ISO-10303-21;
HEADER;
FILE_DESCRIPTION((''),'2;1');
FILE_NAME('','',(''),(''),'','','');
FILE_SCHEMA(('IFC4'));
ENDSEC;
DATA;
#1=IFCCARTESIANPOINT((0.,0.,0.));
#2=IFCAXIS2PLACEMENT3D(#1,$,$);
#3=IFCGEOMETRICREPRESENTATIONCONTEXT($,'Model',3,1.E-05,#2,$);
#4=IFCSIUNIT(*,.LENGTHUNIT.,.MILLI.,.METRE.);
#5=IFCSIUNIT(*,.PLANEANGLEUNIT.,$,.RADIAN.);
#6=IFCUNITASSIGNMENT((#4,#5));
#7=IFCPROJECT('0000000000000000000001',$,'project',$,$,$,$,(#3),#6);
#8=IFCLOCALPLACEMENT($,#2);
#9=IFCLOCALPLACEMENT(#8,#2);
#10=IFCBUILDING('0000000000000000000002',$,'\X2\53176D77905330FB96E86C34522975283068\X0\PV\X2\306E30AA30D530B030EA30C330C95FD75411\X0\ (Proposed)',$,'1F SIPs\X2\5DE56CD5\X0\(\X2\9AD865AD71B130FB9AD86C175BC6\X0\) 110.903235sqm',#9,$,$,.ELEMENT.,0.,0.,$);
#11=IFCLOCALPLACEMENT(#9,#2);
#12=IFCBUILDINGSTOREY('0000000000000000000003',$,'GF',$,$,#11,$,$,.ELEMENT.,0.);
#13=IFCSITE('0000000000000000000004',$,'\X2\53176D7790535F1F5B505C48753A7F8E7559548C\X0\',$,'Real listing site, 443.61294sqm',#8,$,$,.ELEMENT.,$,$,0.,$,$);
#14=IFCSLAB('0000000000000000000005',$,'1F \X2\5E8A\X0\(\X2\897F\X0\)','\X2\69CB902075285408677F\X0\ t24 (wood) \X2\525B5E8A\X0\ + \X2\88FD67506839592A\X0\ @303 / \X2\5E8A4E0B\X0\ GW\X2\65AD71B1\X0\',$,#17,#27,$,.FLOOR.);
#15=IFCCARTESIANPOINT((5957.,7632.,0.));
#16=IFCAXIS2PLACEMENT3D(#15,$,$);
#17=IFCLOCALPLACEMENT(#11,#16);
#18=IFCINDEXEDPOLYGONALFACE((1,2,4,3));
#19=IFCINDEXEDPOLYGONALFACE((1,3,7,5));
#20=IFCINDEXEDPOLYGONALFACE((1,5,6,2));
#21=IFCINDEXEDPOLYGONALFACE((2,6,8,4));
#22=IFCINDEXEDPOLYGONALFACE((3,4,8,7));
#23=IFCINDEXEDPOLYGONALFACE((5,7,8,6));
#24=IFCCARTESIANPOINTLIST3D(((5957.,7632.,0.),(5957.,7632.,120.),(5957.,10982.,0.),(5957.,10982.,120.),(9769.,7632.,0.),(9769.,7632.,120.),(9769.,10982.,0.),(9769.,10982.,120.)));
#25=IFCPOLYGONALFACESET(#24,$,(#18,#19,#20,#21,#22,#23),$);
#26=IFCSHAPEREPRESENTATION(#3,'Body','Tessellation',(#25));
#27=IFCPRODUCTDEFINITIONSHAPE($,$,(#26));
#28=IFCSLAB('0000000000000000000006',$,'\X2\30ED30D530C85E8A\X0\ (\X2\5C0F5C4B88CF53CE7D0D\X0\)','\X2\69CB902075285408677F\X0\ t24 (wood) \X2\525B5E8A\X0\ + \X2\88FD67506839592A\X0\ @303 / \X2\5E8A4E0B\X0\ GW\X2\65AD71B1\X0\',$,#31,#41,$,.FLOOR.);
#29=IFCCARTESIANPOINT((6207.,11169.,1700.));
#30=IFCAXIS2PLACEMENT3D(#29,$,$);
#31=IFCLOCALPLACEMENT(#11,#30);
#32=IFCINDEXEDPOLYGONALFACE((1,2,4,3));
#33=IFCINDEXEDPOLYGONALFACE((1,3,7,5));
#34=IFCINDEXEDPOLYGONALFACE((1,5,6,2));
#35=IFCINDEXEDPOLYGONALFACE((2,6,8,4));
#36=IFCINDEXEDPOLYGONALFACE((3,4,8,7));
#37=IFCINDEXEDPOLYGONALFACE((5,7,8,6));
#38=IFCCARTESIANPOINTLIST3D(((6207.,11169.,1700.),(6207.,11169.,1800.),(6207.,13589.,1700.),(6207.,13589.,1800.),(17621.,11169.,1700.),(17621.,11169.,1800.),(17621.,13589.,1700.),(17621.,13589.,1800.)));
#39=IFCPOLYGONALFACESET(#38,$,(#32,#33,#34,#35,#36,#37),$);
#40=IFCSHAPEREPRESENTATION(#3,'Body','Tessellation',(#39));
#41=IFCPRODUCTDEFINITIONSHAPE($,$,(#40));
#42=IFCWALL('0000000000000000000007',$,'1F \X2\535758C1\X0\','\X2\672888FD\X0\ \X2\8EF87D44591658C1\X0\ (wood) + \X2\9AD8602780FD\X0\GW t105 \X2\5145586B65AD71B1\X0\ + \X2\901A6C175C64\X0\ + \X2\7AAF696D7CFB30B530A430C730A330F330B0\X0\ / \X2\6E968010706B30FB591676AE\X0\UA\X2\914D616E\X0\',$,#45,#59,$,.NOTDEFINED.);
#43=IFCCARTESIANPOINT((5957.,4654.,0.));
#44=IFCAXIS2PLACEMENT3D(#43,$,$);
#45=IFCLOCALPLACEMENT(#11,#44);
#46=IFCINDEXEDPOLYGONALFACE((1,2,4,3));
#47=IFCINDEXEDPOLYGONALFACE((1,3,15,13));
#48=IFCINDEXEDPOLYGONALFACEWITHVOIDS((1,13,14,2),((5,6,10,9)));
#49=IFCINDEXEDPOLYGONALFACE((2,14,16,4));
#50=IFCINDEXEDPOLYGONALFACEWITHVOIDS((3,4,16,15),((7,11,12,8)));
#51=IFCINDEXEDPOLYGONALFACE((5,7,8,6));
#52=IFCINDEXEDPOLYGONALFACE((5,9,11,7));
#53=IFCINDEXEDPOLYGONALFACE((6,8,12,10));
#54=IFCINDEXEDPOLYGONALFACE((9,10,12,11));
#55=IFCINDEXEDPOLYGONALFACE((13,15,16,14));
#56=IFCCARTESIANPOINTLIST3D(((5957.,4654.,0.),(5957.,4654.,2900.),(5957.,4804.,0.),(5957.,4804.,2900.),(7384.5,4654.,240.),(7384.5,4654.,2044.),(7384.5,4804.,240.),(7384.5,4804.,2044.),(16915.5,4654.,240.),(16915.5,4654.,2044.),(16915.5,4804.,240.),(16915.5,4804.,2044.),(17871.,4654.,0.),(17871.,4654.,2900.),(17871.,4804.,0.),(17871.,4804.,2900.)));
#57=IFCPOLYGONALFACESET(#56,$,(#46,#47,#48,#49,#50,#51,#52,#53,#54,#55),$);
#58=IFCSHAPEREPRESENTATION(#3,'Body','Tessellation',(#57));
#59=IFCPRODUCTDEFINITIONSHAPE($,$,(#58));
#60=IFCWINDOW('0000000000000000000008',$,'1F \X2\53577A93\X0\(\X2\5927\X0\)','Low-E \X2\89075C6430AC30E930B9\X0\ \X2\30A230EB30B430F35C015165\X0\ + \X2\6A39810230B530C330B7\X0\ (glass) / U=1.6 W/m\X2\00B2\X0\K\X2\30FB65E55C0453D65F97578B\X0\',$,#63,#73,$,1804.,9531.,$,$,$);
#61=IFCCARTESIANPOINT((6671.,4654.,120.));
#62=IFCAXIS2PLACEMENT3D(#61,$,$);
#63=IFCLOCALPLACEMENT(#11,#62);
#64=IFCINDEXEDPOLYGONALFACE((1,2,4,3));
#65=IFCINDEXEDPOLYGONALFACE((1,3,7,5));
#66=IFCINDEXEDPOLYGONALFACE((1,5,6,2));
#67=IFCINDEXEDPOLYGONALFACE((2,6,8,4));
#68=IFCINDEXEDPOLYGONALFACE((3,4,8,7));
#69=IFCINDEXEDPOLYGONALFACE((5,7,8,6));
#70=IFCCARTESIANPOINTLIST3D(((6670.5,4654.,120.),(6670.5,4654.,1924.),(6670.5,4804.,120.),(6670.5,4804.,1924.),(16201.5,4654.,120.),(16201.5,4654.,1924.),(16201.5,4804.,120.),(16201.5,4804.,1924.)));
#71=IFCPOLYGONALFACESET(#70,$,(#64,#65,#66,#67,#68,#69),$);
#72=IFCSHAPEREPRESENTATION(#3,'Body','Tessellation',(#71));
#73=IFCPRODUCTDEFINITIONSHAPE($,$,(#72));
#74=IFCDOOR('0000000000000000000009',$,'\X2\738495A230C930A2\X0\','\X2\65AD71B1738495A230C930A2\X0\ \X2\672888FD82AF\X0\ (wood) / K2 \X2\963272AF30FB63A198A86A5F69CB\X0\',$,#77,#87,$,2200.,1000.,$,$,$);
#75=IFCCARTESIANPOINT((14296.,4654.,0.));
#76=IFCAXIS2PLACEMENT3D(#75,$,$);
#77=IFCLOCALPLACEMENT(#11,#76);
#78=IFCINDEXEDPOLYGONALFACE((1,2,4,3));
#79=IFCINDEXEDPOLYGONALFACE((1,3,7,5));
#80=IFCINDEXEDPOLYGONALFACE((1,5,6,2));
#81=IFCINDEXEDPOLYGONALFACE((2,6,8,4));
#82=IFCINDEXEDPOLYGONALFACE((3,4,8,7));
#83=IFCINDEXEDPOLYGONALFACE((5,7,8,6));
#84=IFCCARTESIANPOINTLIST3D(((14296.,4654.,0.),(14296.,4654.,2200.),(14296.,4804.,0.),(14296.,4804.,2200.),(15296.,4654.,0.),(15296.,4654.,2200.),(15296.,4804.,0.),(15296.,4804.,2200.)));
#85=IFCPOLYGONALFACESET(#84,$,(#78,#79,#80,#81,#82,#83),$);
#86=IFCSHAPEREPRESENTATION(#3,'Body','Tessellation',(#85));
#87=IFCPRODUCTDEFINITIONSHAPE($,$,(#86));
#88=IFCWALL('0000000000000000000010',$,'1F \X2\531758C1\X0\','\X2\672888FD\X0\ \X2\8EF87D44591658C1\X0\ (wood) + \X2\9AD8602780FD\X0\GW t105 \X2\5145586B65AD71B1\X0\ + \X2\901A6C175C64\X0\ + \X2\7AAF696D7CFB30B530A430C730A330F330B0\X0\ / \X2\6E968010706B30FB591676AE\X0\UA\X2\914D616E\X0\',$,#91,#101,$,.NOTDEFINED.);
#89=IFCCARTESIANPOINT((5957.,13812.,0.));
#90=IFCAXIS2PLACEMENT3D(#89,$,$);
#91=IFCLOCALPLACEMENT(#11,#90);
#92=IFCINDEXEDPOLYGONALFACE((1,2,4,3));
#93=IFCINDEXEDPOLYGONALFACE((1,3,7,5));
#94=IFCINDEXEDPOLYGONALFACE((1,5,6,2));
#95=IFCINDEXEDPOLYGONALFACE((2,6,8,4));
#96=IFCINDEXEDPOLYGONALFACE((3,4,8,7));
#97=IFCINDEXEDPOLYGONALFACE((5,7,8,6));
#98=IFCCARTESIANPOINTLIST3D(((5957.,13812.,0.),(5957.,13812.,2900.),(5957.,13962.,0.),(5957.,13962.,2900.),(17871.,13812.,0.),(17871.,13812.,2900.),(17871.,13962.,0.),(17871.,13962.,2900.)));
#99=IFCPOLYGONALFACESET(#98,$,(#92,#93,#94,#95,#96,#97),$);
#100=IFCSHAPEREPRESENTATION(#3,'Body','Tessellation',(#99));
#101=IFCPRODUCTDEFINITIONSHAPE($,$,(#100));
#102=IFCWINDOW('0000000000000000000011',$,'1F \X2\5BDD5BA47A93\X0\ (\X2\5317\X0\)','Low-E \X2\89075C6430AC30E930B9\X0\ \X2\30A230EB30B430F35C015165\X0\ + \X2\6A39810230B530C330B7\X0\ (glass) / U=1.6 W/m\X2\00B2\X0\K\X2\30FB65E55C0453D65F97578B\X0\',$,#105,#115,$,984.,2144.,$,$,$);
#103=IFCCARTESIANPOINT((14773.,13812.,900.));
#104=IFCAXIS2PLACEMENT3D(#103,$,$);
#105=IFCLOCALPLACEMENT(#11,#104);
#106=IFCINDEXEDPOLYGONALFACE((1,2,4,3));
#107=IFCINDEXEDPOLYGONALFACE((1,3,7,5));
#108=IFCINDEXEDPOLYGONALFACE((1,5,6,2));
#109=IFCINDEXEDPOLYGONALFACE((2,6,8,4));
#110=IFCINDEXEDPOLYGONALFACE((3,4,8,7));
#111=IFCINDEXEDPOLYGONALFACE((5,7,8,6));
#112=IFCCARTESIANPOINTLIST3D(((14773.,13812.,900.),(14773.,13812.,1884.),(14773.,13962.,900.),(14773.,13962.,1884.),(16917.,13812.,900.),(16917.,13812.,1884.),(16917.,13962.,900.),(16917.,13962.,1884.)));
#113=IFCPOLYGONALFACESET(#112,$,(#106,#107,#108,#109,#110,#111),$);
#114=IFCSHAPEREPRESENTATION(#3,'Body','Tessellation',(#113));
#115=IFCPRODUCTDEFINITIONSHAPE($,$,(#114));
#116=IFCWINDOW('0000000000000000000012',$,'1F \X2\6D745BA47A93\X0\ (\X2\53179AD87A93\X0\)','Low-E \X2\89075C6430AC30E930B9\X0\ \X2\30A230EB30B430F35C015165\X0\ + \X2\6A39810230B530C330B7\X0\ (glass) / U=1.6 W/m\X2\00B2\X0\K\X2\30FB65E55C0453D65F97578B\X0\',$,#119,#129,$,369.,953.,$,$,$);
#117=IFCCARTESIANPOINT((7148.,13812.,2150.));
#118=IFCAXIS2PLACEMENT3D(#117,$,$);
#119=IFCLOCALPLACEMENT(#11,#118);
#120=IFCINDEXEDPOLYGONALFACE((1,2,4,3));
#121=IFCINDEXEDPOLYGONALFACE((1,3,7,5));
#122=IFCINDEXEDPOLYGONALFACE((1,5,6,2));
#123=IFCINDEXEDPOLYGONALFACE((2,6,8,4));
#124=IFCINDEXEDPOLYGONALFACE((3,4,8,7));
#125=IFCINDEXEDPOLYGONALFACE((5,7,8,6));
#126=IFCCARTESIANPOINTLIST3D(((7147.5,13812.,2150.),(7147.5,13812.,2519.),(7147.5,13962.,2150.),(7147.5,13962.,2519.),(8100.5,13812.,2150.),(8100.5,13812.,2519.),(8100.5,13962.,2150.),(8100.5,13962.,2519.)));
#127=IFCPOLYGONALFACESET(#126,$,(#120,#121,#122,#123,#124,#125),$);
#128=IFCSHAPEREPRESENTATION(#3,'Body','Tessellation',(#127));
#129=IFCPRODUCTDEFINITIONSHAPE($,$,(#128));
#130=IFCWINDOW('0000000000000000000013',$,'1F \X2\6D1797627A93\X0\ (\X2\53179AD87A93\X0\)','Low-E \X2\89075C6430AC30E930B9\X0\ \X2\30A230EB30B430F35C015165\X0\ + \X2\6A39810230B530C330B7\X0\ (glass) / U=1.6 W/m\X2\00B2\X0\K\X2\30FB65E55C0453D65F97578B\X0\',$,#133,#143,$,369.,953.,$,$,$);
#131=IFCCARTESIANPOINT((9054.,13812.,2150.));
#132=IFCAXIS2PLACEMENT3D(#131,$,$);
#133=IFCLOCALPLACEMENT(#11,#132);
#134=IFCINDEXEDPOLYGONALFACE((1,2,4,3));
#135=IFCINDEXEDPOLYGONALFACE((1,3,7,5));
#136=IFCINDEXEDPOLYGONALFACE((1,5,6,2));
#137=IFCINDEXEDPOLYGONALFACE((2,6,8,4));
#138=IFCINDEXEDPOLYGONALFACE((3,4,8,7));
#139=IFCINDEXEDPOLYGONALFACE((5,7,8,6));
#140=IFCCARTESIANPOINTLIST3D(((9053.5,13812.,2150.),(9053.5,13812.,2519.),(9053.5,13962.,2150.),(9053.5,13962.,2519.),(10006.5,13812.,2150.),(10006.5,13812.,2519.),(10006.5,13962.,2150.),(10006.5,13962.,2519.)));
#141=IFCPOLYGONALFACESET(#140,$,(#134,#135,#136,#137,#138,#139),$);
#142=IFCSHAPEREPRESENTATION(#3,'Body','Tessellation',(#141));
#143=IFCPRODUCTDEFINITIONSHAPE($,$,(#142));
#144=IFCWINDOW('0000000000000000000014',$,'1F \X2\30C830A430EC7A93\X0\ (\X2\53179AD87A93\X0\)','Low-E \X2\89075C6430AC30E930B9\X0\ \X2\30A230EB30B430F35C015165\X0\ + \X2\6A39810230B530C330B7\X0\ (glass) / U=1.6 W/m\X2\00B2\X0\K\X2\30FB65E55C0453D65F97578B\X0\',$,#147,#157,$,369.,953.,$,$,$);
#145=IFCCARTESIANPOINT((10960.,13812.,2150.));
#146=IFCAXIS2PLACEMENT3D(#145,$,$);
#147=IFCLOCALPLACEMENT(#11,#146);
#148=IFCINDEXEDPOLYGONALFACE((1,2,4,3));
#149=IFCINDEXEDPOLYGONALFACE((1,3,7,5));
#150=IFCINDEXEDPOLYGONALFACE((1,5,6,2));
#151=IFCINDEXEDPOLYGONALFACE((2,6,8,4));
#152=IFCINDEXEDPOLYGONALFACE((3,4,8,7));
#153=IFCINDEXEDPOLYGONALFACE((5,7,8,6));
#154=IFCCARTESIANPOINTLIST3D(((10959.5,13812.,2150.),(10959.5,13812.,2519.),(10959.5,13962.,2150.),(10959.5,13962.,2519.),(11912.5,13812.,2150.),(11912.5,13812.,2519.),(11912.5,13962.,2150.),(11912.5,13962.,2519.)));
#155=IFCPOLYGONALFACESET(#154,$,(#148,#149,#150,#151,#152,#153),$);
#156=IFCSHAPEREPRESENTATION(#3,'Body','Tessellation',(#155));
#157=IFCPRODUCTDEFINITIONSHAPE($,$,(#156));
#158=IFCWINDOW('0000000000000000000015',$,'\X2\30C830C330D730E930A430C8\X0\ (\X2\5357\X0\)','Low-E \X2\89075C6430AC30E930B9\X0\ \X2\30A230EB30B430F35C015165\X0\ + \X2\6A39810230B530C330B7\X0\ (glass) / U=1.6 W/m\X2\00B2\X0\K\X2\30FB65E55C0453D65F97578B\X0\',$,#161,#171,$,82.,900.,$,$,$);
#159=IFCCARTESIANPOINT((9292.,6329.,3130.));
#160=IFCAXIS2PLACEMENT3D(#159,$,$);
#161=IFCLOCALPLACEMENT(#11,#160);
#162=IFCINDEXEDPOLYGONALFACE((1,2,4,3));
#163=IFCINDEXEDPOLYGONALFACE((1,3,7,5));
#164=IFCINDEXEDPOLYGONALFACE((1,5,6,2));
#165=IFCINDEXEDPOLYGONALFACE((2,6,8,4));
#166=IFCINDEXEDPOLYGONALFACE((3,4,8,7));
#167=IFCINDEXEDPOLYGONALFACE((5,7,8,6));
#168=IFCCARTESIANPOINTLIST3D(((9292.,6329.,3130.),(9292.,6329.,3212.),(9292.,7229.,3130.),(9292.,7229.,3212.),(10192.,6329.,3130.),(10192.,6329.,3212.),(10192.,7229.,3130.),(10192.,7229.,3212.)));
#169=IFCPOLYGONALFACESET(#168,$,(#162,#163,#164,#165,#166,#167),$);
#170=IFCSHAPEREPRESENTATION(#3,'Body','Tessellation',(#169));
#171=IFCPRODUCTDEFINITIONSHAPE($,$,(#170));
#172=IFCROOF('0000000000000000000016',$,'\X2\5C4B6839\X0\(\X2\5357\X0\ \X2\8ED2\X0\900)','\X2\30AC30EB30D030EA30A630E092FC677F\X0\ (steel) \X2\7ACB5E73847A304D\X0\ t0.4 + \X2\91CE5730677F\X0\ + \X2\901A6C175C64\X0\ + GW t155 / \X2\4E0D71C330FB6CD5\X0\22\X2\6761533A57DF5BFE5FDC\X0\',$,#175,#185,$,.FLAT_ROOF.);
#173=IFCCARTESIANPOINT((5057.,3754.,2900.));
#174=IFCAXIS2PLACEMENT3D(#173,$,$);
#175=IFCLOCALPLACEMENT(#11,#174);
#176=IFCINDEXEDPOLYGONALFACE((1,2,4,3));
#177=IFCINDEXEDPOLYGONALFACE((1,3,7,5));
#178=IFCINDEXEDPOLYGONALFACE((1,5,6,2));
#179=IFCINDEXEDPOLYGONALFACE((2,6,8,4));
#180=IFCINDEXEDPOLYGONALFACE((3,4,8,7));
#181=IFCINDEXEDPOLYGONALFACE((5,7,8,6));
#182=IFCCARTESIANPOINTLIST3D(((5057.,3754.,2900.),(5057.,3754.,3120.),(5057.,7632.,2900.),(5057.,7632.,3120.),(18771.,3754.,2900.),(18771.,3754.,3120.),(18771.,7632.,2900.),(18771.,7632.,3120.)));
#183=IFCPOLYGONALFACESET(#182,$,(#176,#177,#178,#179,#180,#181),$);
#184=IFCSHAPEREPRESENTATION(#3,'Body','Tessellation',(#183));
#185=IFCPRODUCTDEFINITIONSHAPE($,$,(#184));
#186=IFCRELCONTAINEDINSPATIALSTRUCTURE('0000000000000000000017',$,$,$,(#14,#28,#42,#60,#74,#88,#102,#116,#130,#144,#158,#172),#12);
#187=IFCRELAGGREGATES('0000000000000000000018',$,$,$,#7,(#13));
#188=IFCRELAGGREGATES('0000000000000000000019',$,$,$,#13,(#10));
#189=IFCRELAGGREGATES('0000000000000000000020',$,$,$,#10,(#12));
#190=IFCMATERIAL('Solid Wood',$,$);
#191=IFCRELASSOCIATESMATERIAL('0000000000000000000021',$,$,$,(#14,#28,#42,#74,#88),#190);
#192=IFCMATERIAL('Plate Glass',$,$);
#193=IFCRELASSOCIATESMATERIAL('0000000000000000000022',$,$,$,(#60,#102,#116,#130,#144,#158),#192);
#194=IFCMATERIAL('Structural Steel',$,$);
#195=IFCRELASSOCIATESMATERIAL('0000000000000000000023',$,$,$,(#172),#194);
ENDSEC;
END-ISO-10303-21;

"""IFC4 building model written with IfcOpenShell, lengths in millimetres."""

from ifc_helpers import new_model, si_unit, frame, frame_2d, origin, place, context, project, spatial, rectangle, extrude, material, element, fill, save


model = new_model("IFC4")

# Units and contexts
model_context = context("Model", 3, precision=1e-05, world=origin())
ifc_project = project(units=[si_unit("LENGTHUNIT", "METRE", prefix="MILLI"), si_unit("PLANEANGLEUNIT", "RADIAN")], contexts=[model_context])

# Site, building, storey
site_placement = place(None, origin())
site = spatial("IfcSite", under=ifc_project, at=site_placement, Name="北海道弟子屈町美留和", ObjectType="Real listing site, 443.61294sqm", CompositionType="ELEMENT", RefElevation=0.0)
building_placement = place(site_placement, origin())
building = spatial("IfcBuilding", under=site, at=building_placement, Name="北海道・雨水利用とPVのオフグリッド志向 (Proposed)", ObjectType="1F SIPs工法(高断熱・高気密) 110.903235sqm", CompositionType="ELEMENT", ElevationOfRefHeight=0.0, ElevationOfTerrain=0.0)
storey_placement = place(building_placement, origin())
storey = spatial("IfcBuildingStorey", under=building, at=storey_placement, Name="GF", CompositionType="ELEMENT", Elevation=0.0)

# Slabs
ifc_material_1 = material(Name="Solid Wood")
slab_1_placement = place(storey_placement, frame((5957.0, 7632.0, 0.0)))
element("IfcSlab", 1, at=slab_1_placement, inside=storey, material=ifc_material_1, Name="1F 床(西)", Description="構造用合板 t24 (wood) 剛床 + 製材根太 @303 / 床下 GW断熱", PredefinedType="FLOOR", context=model_context, shape_type="SweptSolid", body=[
    extrude(rectangle(XDim=3812.0, YDim=3350.0, at=frame_2d((1906.0, 1675.0))), frame((5957.0, 7632.0, 0.0)), (0.0, 0.0, 1.0), 120.0),
])
slab_2_placement = place(storey_placement, frame((6207.0, 11169.0, 1700.0)))
element("IfcSlab", 2, at=slab_2_placement, inside=storey, material=ifc_material_1, Name="ロフト床 (小屋裏収納)", Description="構造用合板 t24 (wood) 剛床 + 製材根太 @303 / 床下 GW断熱", PredefinedType="FLOOR", context=model_context, shape_type="SweptSolid", body=[
    extrude(rectangle(XDim=11414.0, YDim=2420.0, at=frame_2d((5707.0, 1210.0))), frame((6207.0, 11169.0, 1700.0)), (0.0, 0.0, 1.0), 100.0),
])

# Wall, openings, window, door
wall_1_placement = place(storey_placement, frame((5957.0, 4654.0, 0.0)))
wall_1 = element("IfcWall", 3, at=wall_1_placement, inside=storey, material=ifc_material_1, Name="1F 南壁", Description="木製 軸組外壁 (wood) + 高性能GW t105 充填断熱 + 通気層 + 窯業系サイディング / 準耐火・外皮UA配慮", PredefinedType="NOTDEFINED", context=model_context, shape_type="SweptSolid", body=[
    extrude(rectangle(XDim=11914.0, YDim=150.0, at=frame_2d((5957.0, 75.0))), frame((5957.0, 4654.0, 0.0)), (0.0, 0.0, 1.0), 2900.0),
])
opening_1_placement = place(storey_placement, frame((6671.0, 4654.0, 120.0)))
opening_1 = element("IfcOpeningElement", 4, at=opening_1_placement, cuts=wall_1, PredefinedType="NOTDEFINED", context=model_context, shape_type="SweptSolid", body=[
    extrude(rectangle(XDim=9531.0, YDim=150.0, at=frame_2d((4765.0, 75.0))), frame((6671.0, 4654.0, 120.0)), (0.0, 0.0, 1.0), 1804.0),
])
opening_2_placement = place(storey_placement, frame((14296.0, 4654.0, 0.0)))
opening_2 = element("IfcOpeningElement", 5, at=opening_2_placement, cuts=wall_1, PredefinedType="NOTDEFINED", context=model_context, shape_type="SweptSolid", body=[
    extrude(rectangle(XDim=1000.0, YDim=150.0, at=frame_2d((500.0, 75.0))), frame((14296.0, 4654.0, 0.0)), (0.0, 0.0, 1.0), 2200.0),
])
ifc_material_2 = material(Name="Plate Glass")
window_1_placement = place(storey_placement, frame((6671.0, 4654.0, 120.0)))
window_1 = element("IfcWindow", 6, at=window_1_placement, inside=storey, material=ifc_material_2, Name="1F 南窓(大)", Description="Low-E 複層ガラス アルゴン封入 + 樹脂サッシ (glass) / U=1.6 W/m²K・日射取得型", OverallHeight=1804.0, OverallWidth=9531.0, context=model_context, shape_type="SweptSolid", body=[
    extrude(rectangle(XDim=9531.0, YDim=150.0, at=frame_2d((4765.0, 75.0))), frame((6671.0, 4654.0, 120.0)), (0.0, 0.0, 1.0), 1804.0),
])
fill(opening_1, window_1)
door_1_placement = place(storey_placement, frame((14296.0, 4654.0, 0.0)))
door_1 = element("IfcDoor", 7, at=door_1_placement, inside=storey, material=ifc_material_1, Name="玄関ドア", Description="断熱玄関ドア 木製芯 (wood) / K2 防犯・採風機構", OverallHeight=2200.0, OverallWidth=1000.0, context=model_context, shape_type="SweptSolid", body=[
    extrude(rectangle(XDim=1000.0, YDim=150.0, at=frame_2d((500.0, 75.0))), frame((14296.0, 4654.0, 0.0)), (0.0, 0.0, 1.0), 2200.0),
])
fill(opening_2, door_1)

# Wall, openings, windows
wall_2_placement = place(storey_placement, frame((5957.0, 13812.0, 0.0)))
wall_2 = element("IfcWall", 8, at=wall_2_placement, inside=storey, material=ifc_material_1, Name="1F 北壁", Description="木製 軸組外壁 (wood) + 高性能GW t105 充填断熱 + 通気層 + 窯業系サイディング / 準耐火・外皮UA配慮", PredefinedType="NOTDEFINED", context=model_context, shape_type="SweptSolid", body=[
    extrude(rectangle(XDim=11914.0, YDim=150.0, at=frame_2d((5957.0, 75.0))), frame((5957.0, 13812.0, 0.0)), (0.0, 0.0, 1.0), 2900.0),
])
opening_3_placement = place(storey_placement, frame((14773.0, 13812.0, 900.0)))
opening_3 = element("IfcOpeningElement", 9, at=opening_3_placement, cuts=wall_2, PredefinedType="NOTDEFINED", context=model_context, shape_type="SweptSolid", body=[
    extrude(rectangle(XDim=2144.0, YDim=150.0, at=frame_2d((1072.0, 75.0))), frame((14773.0, 13812.0, 900.0)), (0.0, 0.0, 1.0), 984.0),
])
opening_4_placement = place(storey_placement, frame((7148.0, 13812.0, 2150.0)))
opening_4 = element("IfcOpeningElement", 10, at=opening_4_placement, cuts=wall_2, PredefinedType="NOTDEFINED", context=model_context, shape_type="SweptSolid", body=[
    extrude(rectangle(XDim=953.0, YDim=150.0, at=frame_2d((476.0, 75.0))), frame((7148.0, 13812.0, 2150.0)), (0.0, 0.0, 1.0), 369.0),
])
opening_5_placement = place(storey_placement, frame((9054.0, 13812.0, 2150.0)))
opening_5 = element("IfcOpeningElement", 11, at=opening_5_placement, cuts=wall_2, PredefinedType="NOTDEFINED", context=model_context, shape_type="SweptSolid", body=[
    extrude(rectangle(XDim=953.0, YDim=150.0, at=frame_2d((476.0, 75.0))), frame((9054.0, 13812.0, 2150.0)), (0.0, 0.0, 1.0), 369.0),
])
opening_6_placement = place(storey_placement, frame((10960.0, 13812.0, 2150.0)))
opening_6 = element("IfcOpeningElement", 12, at=opening_6_placement, cuts=wall_2, PredefinedType="NOTDEFINED", context=model_context, shape_type="SweptSolid", body=[
    extrude(rectangle(XDim=953.0, YDim=150.0, at=frame_2d((476.0, 75.0))), frame((10960.0, 13812.0, 2150.0)), (0.0, 0.0, 1.0), 369.0),
])
window_2_placement = place(storey_placement, frame((14773.0, 13812.0, 900.0)))
window_2 = element("IfcWindow", 13, at=window_2_placement, inside=storey, material=ifc_material_2, Name="1F 寝室窓 (北)", Description="Low-E 複層ガラス アルゴン封入 + 樹脂サッシ (glass) / U=1.6 W/m²K・日射取得型", OverallHeight=984.0, OverallWidth=2144.0, context=model_context, shape_type="SweptSolid", body=[
    extrude(rectangle(XDim=2144.0, YDim=150.0, at=frame_2d((1072.0, 75.0))), frame((14773.0, 13812.0, 900.0)), (0.0, 0.0, 1.0), 984.0),
])
fill(opening_3, window_2)
window_3_placement = place(storey_placement, frame((7148.0, 13812.0, 2150.0)))
window_3 = element("IfcWindow", 14, at=window_3_placement, inside=storey, material=ifc_material_2, Name="1F 浴室窓 (北高窓)", Description="Low-E 複層ガラス アルゴン封入 + 樹脂サッシ (glass) / U=1.6 W/m²K・日射取得型", OverallHeight=369.0, OverallWidth=953.0, context=model_context, shape_type="SweptSolid", body=[
    extrude(rectangle(XDim=953.0, YDim=150.0, at=frame_2d((476.0, 75.0))), frame((7148.0, 13812.0, 2150.0)), (0.0, 0.0, 1.0), 369.0),
])
fill(opening_4, window_3)
window_4_placement = place(storey_placement, frame((9054.0, 13812.0, 2150.0)))
window_4 = element("IfcWindow", 15, at=window_4_placement, inside=storey, material=ifc_material_2, Name="1F 洗面窓 (北高窓)", Description="Low-E 複層ガラス アルゴン封入 + 樹脂サッシ (glass) / U=1.6 W/m²K・日射取得型", OverallHeight=369.0, OverallWidth=953.0, context=model_context, shape_type="SweptSolid", body=[
    extrude(rectangle(XDim=953.0, YDim=150.0, at=frame_2d((476.0, 75.0))), frame((9054.0, 13812.0, 2150.0)), (0.0, 0.0, 1.0), 369.0),
])
fill(opening_5, window_4)
window_5_placement = place(storey_placement, frame((10960.0, 13812.0, 2150.0)))
window_5 = element("IfcWindow", 16, at=window_5_placement, inside=storey, material=ifc_material_2, Name="1F トイレ窓 (北高窓)", Description="Low-E 複層ガラス アルゴン封入 + 樹脂サッシ (glass) / U=1.6 W/m²K・日射取得型", OverallHeight=369.0, OverallWidth=953.0, context=model_context, shape_type="SweptSolid", body=[
    extrude(rectangle(XDim=953.0, YDim=150.0, at=frame_2d((476.0, 75.0))), frame((10960.0, 13812.0, 2150.0)), (0.0, 0.0, 1.0), 369.0),
])
fill(opening_6, window_5)

# Window
window_6_placement = place(storey_placement, frame((9292.0, 6329.0, 3130.0)))
element("IfcWindow", 17, at=window_6_placement, inside=storey, material=ifc_material_2, Name="トップライト (南)", Description="Low-E 複層ガラス アルゴン封入 + 樹脂サッシ (glass) / U=1.6 W/m²K・日射取得型", OverallHeight=82.0, OverallWidth=900.0, context=model_context, shape_type="SweptSolid", body=[
    extrude(rectangle(XDim=900.0, YDim=900.0, at=frame_2d((450.0, 450.0))), frame((9292.0, 6329.0, 3130.0)), (0.0, 0.0, 1.0), 82.0),
])

# Roof
ifc_material_3 = material(Name="Structural Steel")
roof_1_placement = place(storey_placement, frame((5057.0, 3754.0, 2900.0)))
element("IfcRoof", 18, at=roof_1_placement, inside=storey, material=ifc_material_3, Name="屋根(南 軒900)", Description="ガルバリウム鋼板 (steel) 立平葺き t0.4 + 野地板 + 通気層 + GW t155 / 不燃・法22条区域対応", PredefinedType="FLAT_ROOF", context=model_context, shape_type="SweptSolid", body=[
    extrude(rectangle(XDim=13714.0, YDim=3878.0, at=frame_2d((6857.0, 1939.0))), frame((5057.0, 3754.0, 2900.0)), (0.0, 0.0, 1.0), 220.0),
])

save(model, "model.ifc")
